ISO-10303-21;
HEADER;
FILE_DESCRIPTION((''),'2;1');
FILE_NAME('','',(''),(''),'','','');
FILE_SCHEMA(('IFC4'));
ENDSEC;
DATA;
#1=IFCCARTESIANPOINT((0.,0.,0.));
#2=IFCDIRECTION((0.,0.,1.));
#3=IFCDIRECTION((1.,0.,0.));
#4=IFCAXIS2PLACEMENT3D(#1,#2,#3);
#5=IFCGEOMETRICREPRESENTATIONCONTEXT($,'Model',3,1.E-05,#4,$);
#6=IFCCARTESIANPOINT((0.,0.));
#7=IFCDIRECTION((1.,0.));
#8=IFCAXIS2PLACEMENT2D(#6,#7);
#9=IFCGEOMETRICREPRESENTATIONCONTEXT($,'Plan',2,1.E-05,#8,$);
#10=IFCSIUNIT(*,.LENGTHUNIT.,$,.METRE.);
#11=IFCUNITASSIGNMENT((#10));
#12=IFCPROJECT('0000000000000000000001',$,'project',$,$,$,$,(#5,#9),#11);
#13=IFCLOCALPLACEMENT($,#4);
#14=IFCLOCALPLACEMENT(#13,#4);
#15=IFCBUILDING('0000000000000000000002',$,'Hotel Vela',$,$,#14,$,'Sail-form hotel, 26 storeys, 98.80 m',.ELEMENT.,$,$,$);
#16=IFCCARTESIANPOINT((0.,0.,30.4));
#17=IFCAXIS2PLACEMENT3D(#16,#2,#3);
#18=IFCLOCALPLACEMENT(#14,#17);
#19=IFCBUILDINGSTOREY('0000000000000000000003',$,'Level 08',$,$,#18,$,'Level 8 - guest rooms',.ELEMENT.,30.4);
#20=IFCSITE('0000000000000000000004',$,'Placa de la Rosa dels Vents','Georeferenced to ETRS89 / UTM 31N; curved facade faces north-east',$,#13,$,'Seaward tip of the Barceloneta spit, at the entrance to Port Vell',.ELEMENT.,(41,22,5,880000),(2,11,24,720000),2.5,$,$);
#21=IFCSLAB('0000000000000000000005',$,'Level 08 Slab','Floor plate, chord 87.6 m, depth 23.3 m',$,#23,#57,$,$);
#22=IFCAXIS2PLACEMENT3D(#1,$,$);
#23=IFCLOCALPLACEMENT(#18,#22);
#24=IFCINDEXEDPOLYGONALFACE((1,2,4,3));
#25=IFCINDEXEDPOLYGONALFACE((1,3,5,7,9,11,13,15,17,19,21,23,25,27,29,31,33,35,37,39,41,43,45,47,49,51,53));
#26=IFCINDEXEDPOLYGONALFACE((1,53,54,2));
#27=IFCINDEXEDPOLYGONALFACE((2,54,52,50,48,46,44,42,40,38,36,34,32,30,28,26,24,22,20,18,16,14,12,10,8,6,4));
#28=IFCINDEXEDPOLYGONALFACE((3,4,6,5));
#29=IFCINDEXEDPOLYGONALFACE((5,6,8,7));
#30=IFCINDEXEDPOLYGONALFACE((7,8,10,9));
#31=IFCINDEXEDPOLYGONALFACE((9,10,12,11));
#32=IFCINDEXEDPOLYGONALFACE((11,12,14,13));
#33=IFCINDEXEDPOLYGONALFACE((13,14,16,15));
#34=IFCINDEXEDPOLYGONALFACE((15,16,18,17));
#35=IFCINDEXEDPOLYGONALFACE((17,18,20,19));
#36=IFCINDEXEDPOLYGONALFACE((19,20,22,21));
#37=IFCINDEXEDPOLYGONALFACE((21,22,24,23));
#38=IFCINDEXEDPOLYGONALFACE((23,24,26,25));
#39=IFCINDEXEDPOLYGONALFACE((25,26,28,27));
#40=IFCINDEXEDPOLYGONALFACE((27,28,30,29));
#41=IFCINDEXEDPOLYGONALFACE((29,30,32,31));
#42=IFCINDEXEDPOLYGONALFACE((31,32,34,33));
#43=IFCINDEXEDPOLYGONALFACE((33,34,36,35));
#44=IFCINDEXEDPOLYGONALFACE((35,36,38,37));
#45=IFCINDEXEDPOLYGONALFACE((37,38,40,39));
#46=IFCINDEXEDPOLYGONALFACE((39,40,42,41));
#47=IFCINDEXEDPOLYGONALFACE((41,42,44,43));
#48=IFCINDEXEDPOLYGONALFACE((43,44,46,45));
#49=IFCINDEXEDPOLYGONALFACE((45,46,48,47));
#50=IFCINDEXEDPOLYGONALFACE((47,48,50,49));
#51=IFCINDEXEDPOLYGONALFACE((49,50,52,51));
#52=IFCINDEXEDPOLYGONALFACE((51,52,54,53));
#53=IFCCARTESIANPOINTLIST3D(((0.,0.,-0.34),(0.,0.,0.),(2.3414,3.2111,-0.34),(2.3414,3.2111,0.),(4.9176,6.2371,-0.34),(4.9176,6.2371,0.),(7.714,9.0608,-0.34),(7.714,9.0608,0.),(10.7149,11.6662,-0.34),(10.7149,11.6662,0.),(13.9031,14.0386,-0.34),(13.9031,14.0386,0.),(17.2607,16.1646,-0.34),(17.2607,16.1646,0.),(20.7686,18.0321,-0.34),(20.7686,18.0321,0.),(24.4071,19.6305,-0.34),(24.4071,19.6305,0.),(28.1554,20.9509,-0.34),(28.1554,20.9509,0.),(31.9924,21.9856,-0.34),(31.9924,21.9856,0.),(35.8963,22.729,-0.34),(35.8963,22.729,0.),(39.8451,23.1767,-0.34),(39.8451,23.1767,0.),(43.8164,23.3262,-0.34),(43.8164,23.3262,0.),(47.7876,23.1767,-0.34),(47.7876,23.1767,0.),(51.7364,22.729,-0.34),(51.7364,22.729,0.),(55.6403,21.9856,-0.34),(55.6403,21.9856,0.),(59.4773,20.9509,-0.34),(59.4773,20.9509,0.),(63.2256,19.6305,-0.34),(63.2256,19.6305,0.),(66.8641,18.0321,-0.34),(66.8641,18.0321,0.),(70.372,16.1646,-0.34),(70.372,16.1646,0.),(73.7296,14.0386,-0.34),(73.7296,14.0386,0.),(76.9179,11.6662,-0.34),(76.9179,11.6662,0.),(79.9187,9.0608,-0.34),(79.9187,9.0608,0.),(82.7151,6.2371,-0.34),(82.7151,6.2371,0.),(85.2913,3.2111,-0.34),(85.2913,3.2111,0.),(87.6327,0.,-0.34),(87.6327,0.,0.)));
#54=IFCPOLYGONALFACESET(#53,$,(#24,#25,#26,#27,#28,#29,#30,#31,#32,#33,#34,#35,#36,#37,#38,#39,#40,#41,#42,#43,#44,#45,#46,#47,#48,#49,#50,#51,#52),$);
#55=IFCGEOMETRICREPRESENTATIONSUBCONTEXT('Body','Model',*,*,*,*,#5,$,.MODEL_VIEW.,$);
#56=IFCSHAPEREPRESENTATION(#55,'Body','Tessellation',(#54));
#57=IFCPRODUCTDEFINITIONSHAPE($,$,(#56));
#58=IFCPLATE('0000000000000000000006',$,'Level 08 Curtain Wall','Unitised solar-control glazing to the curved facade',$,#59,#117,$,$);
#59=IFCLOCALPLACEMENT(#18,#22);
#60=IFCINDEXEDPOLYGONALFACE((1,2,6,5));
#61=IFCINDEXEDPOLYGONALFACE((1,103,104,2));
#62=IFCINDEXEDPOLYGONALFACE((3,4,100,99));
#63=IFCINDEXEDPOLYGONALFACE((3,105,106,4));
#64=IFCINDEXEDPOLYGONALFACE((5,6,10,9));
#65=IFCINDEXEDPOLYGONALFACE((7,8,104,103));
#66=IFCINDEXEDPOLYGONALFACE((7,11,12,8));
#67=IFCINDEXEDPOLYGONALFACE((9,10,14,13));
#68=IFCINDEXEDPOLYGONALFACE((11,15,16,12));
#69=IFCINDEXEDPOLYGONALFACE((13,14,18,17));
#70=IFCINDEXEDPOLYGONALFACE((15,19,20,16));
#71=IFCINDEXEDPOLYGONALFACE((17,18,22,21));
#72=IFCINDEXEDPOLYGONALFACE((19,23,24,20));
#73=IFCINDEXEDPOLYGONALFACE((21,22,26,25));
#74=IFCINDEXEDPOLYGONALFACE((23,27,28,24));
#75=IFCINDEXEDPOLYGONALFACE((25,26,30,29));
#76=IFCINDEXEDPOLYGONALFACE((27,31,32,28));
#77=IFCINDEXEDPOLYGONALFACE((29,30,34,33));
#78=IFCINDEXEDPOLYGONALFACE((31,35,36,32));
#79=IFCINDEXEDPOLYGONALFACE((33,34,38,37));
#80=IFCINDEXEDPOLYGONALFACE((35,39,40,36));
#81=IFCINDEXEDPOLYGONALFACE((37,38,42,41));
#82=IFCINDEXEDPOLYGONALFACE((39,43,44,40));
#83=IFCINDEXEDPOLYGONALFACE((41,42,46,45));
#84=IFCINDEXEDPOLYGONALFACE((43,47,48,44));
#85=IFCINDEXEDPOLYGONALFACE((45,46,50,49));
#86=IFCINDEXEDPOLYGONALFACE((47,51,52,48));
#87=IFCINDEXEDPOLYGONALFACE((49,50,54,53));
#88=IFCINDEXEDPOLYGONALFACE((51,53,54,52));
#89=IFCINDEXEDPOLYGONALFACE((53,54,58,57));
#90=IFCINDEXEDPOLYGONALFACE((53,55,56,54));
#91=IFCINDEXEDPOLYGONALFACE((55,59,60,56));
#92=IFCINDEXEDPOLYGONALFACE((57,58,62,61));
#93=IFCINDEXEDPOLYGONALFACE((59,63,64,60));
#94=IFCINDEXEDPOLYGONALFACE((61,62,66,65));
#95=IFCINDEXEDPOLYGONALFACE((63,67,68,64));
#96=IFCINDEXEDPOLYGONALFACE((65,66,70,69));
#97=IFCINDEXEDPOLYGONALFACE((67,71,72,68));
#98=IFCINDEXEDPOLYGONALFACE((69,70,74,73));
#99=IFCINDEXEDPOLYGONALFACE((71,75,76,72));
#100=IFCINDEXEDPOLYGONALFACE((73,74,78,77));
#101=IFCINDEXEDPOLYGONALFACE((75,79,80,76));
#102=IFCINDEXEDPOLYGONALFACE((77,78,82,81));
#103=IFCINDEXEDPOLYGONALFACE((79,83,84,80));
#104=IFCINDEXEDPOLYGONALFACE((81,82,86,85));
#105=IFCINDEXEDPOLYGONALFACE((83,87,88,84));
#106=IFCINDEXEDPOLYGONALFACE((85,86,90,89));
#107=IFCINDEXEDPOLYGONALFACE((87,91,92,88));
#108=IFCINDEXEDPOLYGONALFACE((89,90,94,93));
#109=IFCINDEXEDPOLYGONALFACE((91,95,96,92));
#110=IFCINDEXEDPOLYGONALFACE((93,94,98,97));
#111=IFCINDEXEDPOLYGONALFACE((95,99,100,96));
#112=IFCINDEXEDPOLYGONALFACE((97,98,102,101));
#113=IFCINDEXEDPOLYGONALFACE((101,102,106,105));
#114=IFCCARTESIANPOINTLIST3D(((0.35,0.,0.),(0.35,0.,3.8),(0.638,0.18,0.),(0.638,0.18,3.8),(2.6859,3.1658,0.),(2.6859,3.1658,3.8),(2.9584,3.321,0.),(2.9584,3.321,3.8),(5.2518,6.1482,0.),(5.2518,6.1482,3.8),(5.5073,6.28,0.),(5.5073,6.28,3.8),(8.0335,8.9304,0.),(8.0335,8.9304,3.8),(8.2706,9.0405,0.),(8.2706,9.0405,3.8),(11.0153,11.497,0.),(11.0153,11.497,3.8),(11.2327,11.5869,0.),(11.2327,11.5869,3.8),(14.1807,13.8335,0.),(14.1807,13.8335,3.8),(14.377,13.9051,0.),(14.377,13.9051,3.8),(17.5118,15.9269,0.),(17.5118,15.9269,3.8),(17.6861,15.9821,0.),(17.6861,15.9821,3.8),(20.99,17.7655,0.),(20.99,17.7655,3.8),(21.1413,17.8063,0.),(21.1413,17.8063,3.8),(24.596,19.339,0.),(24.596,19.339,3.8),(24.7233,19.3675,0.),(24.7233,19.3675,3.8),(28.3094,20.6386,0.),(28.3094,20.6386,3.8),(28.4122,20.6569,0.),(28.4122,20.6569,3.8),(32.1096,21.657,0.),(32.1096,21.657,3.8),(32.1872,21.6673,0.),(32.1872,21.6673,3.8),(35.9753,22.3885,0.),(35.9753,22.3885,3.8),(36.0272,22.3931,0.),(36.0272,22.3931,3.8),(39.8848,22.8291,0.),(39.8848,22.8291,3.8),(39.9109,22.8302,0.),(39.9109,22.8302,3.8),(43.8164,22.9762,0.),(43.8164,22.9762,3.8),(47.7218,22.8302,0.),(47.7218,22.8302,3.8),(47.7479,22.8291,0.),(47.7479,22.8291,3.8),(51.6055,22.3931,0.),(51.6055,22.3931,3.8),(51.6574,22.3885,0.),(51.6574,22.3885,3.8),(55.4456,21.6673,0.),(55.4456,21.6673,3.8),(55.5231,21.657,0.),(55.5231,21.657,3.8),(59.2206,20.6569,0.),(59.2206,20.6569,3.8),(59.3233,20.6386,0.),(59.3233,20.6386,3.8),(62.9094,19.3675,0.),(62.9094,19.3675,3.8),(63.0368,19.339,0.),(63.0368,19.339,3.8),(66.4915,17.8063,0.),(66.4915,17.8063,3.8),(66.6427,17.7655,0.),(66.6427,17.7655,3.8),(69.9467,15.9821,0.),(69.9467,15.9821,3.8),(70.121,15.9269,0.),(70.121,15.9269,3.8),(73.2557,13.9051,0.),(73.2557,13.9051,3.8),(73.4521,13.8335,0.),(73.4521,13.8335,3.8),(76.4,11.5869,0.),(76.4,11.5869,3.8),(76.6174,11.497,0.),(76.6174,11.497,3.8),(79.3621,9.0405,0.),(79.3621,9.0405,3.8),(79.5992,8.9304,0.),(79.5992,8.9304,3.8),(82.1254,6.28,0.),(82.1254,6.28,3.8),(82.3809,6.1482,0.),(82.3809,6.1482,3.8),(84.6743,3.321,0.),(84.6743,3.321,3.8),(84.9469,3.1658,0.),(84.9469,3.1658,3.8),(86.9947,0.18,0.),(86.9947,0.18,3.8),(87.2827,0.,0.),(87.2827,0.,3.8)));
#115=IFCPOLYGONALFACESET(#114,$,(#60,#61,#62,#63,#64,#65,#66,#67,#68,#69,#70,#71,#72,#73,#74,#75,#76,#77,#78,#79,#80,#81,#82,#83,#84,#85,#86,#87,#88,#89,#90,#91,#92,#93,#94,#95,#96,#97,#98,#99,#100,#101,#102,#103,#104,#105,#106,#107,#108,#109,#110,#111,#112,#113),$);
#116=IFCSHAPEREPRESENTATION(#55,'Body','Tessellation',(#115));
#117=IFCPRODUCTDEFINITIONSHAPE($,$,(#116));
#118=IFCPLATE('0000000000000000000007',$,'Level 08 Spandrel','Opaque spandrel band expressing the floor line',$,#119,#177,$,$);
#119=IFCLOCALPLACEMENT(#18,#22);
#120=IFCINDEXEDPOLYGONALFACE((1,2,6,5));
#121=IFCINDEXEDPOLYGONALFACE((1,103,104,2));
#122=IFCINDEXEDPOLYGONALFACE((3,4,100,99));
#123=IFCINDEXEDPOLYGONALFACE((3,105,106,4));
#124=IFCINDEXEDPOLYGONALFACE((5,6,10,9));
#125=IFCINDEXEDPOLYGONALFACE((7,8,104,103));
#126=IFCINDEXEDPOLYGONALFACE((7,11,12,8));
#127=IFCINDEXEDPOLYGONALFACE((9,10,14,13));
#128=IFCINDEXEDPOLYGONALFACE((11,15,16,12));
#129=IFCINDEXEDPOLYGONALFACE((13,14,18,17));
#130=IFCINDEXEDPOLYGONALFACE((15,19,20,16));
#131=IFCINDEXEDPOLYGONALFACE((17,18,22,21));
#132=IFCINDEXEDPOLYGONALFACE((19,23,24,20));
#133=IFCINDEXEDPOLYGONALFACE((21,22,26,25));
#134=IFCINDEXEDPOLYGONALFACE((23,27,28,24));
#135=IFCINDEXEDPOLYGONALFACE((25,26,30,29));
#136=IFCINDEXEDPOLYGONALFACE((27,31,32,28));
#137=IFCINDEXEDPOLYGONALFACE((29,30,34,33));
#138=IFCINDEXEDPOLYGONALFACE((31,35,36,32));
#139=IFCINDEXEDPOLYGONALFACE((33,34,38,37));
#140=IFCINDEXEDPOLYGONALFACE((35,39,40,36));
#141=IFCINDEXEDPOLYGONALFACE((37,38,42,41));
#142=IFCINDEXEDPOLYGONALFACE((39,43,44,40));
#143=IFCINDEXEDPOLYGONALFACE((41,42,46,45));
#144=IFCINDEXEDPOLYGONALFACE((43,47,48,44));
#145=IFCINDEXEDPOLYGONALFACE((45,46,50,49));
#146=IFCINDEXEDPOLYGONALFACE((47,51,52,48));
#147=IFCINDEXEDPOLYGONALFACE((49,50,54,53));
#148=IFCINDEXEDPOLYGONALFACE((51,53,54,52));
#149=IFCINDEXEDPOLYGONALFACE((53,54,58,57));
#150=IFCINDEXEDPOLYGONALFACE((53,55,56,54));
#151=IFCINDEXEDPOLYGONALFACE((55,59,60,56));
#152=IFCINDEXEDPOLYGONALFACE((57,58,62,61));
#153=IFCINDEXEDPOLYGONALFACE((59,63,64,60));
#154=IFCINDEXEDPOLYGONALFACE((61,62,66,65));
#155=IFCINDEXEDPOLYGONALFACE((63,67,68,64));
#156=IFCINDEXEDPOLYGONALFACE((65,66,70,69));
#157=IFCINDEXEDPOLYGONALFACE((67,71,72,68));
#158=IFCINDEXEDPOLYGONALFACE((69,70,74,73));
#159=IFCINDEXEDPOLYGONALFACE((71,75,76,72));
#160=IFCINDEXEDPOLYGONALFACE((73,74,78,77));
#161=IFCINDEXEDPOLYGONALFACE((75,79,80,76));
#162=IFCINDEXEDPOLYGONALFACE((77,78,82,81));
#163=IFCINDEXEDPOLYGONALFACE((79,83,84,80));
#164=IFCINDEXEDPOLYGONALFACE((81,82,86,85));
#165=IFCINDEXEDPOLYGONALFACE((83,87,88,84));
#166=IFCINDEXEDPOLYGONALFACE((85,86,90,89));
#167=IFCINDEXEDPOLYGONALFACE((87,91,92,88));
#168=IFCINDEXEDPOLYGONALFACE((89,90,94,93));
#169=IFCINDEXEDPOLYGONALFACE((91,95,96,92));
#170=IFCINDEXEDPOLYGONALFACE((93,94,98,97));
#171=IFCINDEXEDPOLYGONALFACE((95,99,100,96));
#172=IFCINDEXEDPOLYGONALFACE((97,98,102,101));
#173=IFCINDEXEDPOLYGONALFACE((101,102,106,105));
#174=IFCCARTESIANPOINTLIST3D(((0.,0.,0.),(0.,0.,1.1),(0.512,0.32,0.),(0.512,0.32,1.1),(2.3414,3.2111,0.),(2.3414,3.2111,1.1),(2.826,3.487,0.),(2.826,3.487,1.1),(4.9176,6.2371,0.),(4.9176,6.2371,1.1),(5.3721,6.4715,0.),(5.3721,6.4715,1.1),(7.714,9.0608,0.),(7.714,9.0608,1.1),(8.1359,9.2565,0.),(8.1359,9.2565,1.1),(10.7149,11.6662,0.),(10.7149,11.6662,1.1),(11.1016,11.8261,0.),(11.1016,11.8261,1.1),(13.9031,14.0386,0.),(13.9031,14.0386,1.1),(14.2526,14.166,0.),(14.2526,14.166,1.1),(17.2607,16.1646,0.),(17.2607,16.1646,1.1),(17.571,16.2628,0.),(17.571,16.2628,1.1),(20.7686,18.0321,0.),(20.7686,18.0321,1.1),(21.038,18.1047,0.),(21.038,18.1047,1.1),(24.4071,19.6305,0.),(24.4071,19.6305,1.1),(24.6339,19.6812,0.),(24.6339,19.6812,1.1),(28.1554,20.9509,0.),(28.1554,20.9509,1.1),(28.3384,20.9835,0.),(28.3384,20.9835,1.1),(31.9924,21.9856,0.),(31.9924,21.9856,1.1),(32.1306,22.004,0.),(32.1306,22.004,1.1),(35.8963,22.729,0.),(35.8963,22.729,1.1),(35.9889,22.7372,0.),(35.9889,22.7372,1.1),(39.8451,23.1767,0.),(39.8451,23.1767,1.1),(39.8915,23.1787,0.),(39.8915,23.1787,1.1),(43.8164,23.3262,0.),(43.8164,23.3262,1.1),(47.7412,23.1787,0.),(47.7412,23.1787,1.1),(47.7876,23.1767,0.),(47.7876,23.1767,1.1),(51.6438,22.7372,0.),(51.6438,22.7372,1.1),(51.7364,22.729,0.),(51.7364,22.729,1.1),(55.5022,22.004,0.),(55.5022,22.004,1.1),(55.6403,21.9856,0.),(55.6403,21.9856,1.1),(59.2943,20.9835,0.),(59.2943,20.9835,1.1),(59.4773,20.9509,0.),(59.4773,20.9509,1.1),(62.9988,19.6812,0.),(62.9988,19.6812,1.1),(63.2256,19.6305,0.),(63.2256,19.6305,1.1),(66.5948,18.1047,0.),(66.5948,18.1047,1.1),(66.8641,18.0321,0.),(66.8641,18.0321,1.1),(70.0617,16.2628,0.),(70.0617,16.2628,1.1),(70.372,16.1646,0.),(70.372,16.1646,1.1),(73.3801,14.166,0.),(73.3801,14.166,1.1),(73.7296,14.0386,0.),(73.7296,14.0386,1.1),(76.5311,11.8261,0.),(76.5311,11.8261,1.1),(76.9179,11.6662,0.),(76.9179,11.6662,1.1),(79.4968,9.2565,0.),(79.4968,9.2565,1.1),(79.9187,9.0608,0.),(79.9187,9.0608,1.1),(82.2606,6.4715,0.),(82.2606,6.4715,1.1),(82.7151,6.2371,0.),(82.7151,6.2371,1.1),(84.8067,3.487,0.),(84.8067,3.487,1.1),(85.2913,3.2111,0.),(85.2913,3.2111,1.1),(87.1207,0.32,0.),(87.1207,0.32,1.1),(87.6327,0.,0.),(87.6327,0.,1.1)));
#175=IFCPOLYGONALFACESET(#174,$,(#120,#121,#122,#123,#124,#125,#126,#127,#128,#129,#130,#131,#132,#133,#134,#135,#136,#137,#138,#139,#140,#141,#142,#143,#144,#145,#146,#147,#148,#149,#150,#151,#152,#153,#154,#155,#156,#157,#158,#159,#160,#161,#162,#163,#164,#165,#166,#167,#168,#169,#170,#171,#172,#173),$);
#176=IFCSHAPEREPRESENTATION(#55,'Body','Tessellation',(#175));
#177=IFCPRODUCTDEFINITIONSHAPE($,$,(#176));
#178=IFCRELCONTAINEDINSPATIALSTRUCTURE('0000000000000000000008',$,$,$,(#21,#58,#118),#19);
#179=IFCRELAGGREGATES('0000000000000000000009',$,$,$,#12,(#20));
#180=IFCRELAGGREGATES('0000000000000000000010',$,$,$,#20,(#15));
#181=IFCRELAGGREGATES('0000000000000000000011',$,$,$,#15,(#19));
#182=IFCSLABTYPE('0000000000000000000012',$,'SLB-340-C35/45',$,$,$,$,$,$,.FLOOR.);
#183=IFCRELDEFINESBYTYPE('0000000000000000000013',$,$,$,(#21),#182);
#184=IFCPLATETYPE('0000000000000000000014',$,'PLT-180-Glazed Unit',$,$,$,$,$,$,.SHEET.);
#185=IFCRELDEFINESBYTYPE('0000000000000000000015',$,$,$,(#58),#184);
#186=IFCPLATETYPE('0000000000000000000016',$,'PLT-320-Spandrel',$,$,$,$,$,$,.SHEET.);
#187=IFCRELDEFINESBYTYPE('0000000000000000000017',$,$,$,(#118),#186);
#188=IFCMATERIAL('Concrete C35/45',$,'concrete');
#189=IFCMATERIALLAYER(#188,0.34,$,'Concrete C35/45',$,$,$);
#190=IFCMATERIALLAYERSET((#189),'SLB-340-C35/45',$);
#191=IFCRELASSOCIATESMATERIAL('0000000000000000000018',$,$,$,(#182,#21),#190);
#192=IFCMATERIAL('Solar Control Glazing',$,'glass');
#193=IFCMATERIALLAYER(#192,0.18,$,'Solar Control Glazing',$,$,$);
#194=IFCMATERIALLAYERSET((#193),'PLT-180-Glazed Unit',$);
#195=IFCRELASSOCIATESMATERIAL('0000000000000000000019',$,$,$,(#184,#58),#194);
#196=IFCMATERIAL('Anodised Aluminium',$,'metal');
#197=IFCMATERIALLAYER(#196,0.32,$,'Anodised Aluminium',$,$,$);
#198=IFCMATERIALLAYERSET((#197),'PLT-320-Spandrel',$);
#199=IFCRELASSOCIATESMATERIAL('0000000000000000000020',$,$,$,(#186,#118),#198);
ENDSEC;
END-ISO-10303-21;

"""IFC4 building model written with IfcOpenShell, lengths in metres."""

from ifc_helpers import new_model, si_unit, frame, origin_with_axes, origin_2d_with_axis, place, context, subcontext, project, spatial, line, indexed_curve, outline, extrude, material, layer, layer_set, layer_usage, type_object, element, save


model = new_model("IFC4")

# Units and contexts
model_context = context("Model", 3, precision=1e-05, world=origin_with_axes())
plan_context = context("Plan", 2, precision=1e-05, world=origin_2d_with_axis())
body_context = subcontext(model_context, "Body", "Model", "MODEL_VIEW")
ifc_project = project(units=[si_unit("LENGTHUNIT", "METRE")], contexts=[model_context, plan_context])

# Site, building, storey
site_placement = place(None, origin_with_axes())
site = spatial("IfcSite", under=ifc_project, at=site_placement, Name="Placa de la Rosa dels Vents", Description="Georeferenced to ETRS89 / UTM 31N; curved facade faces north-east", LongName="Seaward tip of the Barceloneta spit, at the entrance to Port Vell", CompositionType="ELEMENT", RefLatitude=(41, 22, 5, 880000), RefLongitude=(2, 11, 24, 720000), RefElevation=2.5)
building_placement = place(site_placement, origin_with_axes())
building = spatial("IfcBuilding", under=site, at=building_placement, Name="Hotel Vela", LongName="Sail-form hotel, 26 storeys, 98.80 m", CompositionType="ELEMENT")
storey_placement = place(building_placement, frame((0.0, 0.0, 30.4), z_axis=(0.0, 0.0, 1.0), x_axis=(1.0, 0.0, 0.0)))
storey = spatial("IfcBuildingStorey", under=building, at=storey_placement, Name="Level 08", LongName="Level 8 - guest rooms", CompositionType="ELEMENT", Elevation=30.4)

# Slab
ifc_material_1 = material(Name="Concrete C35/45", Category="concrete")
ifc_layer_1 = layer(ifc_material_1, 0.34, Name="Concrete C35/45")
ifc_layer_set_1 = layer_set([ifc_layer_1], Name="SLB-340-C35/45")
ifc_layer_usage_1 = layer_usage(ifc_layer_set_1, "AXIS3", "POSITIVE", 0.0)
slab_type = type_object("IfcSlabType", Name="SLB-340-C35/45", PredefinedType="FLOOR", material=ifc_layer_set_1)
slab_placement = place(storey_placement, frame((0.0, 0.0, -0.34), z_axis=(0.0, 0.0, 1.0), x_axis=(1.0, 0.0, 0.0)))
element("IfcSlab", 1, at=slab_placement, inside=storey, type_object=slab_type, material=ifc_layer_usage_1, Name="Level 08 Slab", Description="Floor plate, chord 87.6 m, depth 23.3 m", context=body_context, shape_type="SweptSolid", body=[
    extrude(outline(indexed_curve([(0.0, 0.0), (87.6327, 0.0), (85.2913, 3.2111), (82.7151, 6.2371), (79.9187, 9.0608), (76.9179, 11.6662), (73.7296, 14.0386), (70.372, 16.1646), (66.8641, 18.0321), (63.2256, 19.6305), (59.4773, 20.9509), (55.6403, 21.9856), (51.7364, 22.729), (47.7876, 23.1767), (43.8164, 23.3262), (39.8451, 23.1767), (35.8963, 22.729), (31.9924, 21.9856), (28.1554, 20.9509), (24.4071, 19.6305), (20.7686, 18.0321), (17.2607, 16.1646), (13.9031, 14.0386), (10.7149, 11.6662), (7.714, 9.0608), (4.9176, 6.2371), (2.3414, 3.2111)], segments=[line(1, 2, 3, 4, 5, 6, 7, 8, 9, 10, 11, 12, 13, 14, 15, 16, 17, 18, 19, 20, 21, 22, 23, 24, 25, 26, 27, 1)])), origin_with_axes(), (0.0, 0.0, 1.0), 0.34),
])

# Plates
ifc_material_2 = material(Name="Solar Control Glazing", Category="glass")
ifc_layer_2 = layer(ifc_material_2, 0.18, Name="Solar Control Glazing")
ifc_layer_set_2 = layer_set([ifc_layer_2], Name="PLT-180-Glazed Unit")
ifc_layer_usage_2 = layer_usage(ifc_layer_set_2, "AXIS2", "POSITIVE", 0.0)
plate_type_1 = type_object("IfcPlateType", Name="PLT-180-Glazed Unit", PredefinedType="SHEET", material=ifc_layer_set_2)
plate_1_placement = place(storey_placement, frame((0.35, 0.0, 0.0), z_axis=(0.0, 0.0, 1.0), x_axis=(1.0, 0.0, 0.0)))
element("IfcPlate", 2, at=plate_1_placement, inside=storey, type_object=plate_type_1, material=ifc_layer_usage_2, Name="Level 08 Curtain Wall", Description="Unitised solar-control glazing to the curved facade", context=body_context, shape_type="SweptSolid", body=[
    extrude(outline(indexed_curve([(86.9327, 0.0), (84.5969, 3.1658), (82.0309, 6.1482), (79.2492, 8.9304), (76.2674, 11.497), (73.1021, 13.8335), (69.771, 15.9269), (66.2927, 17.7655), (62.6868, 19.339), (58.9733, 20.6386), (55.1731, 21.657), (51.3074, 22.3885), (47.3979, 22.8291), (43.4664, 22.9762), (39.5348, 22.8291), (35.6253, 22.3885), (31.7596, 21.657), (27.9594, 20.6386), (24.246, 19.339), (20.64, 17.7655), (17.1618, 15.9269), (13.8307, 13.8335), (10.6653, 11.497), (7.6835, 8.9304), (4.9018, 6.1482), (2.3359, 3.1658), (0.0, 0.0), (86.6447, 0.18), (2.6084, 3.321), (5.1573, 6.28), (7.9206, 9.0405), (10.8827, 11.5869), (14.027, 13.9051), (17.3361, 15.9821), (20.7913, 17.8063), (24.3733, 19.3675), (28.0622, 20.6569), (31.8372, 21.6673), (35.6772, 22.3931), (39.5609, 22.8302), (43.4664, 22.9762), (47.3718, 22.8302), (51.2555, 22.3931), (55.0956, 21.6673), (58.8706, 20.6569), (62.5594, 19.3675), (66.1415, 17.8063), (69.5967, 15.9821), (72.9057, 13.9051), (76.05, 11.5869), (79.0121, 9.0405), (81.7754, 6.28), (84.3243, 3.321), (0.288, 0.18)], segments=[line(1, 2, 3, 4, 5, 6, 7, 8, 9, 10, 11, 12, 13, 14, 15, 16, 17, 18, 19, 20, 21, 22, 23, 24, 25, 26, 27, 28, 29, 30, 31, 32, 33, 34, 35, 36, 37, 38, 39, 40, 41, 42, 43, 44, 45, 46, 47, 48, 49, 50, 51, 52, 53, 54, 1)])), origin_with_axes(), (0.0, 0.0, 1.0), 3.8),
])
ifc_material_3 = material(Name="Anodised Aluminium", Category="metal")
ifc_layer_3 = layer(ifc_material_3, 0.32, Name="Anodised Aluminium")
ifc_layer_set_3 = layer_set([ifc_layer_3], Name="PLT-320-Spandrel")
ifc_layer_usage_3 = layer_usage(ifc_layer_set_3, "AXIS2", "POSITIVE", 0.0)
plate_type_2 = type_object("IfcPlateType", Name="PLT-320-Spandrel", PredefinedType="SHEET", material=ifc_layer_set_3)
plate_2_placement = place(storey_placement, origin_with_axes())
element("IfcPlate", 3, at=plate_2_placement, inside=storey, type_object=plate_type_2, material=ifc_layer_usage_3, Name="Level 08 Spandrel", Description="Opaque spandrel band expressing the floor line", context=body_context, shape_type="SweptSolid", body=[
    extrude(outline(indexed_curve([(87.6327, 0.0), (85.2913, 3.2111), (82.7151, 6.2371), (79.9187, 9.0608), (76.9179, 11.6662), (73.7296, 14.0386), (70.372, 16.1646), (66.8641, 18.0321), (63.2256, 19.6305), (59.4773, 20.9509), (55.6403, 21.9856), (51.7364, 22.729), (47.7876, 23.1767), (43.8164, 23.3262), (39.8451, 23.1767), (35.8963, 22.729), (31.9924, 21.9856), (28.1554, 20.9509), (24.4071, 19.6305), (20.7686, 18.0321), (17.2607, 16.1646), (13.9031, 14.0386), (10.7149, 11.6662), (7.714, 9.0608), (4.9176, 6.2371), (2.3414, 3.2111), (0.0, 0.0), (87.1207, 0.32), (2.826, 3.487), (5.3721, 6.4715), (8.1359, 9.2565), (11.1016, 11.8261), (14.2526, 14.166), (17.571, 16.2628), (21.038, 18.1047), (24.6339, 19.6812), (28.3384, 20.9835), (32.1306, 22.004), (35.9889, 22.7372), (39.8915, 23.1787), (43.8164, 23.3262), (47.7412, 23.1787), (51.6438, 22.7372), (55.5022, 22.004), (59.2943, 20.9835), (62.9988, 19.6812), (66.5948, 18.1047), (70.0617, 16.2628), (73.3801, 14.166), (76.5311, 11.8261), (79.4968, 9.2565), (82.2606, 6.4715), (84.8067, 3.487), (0.512, 0.32)], segments=[line(1, 2, 3, 4, 5, 6, 7, 8, 9, 10, 11, 12, 13, 14, 15, 16, 17, 18, 19, 20, 21, 22, 23, 24, 25, 26, 27, 28, 29, 30, 31, 32, 33, 34, 35, 36, 37, 38, 39, 40, 41, 42, 43, 44, 45, 46, 47, 48, 49, 50, 51, 52, 53, 54, 1)])), origin_with_axes(), (0.0, 0.0, 1.0), 1.1),
])

save(model, "model.ifc")
